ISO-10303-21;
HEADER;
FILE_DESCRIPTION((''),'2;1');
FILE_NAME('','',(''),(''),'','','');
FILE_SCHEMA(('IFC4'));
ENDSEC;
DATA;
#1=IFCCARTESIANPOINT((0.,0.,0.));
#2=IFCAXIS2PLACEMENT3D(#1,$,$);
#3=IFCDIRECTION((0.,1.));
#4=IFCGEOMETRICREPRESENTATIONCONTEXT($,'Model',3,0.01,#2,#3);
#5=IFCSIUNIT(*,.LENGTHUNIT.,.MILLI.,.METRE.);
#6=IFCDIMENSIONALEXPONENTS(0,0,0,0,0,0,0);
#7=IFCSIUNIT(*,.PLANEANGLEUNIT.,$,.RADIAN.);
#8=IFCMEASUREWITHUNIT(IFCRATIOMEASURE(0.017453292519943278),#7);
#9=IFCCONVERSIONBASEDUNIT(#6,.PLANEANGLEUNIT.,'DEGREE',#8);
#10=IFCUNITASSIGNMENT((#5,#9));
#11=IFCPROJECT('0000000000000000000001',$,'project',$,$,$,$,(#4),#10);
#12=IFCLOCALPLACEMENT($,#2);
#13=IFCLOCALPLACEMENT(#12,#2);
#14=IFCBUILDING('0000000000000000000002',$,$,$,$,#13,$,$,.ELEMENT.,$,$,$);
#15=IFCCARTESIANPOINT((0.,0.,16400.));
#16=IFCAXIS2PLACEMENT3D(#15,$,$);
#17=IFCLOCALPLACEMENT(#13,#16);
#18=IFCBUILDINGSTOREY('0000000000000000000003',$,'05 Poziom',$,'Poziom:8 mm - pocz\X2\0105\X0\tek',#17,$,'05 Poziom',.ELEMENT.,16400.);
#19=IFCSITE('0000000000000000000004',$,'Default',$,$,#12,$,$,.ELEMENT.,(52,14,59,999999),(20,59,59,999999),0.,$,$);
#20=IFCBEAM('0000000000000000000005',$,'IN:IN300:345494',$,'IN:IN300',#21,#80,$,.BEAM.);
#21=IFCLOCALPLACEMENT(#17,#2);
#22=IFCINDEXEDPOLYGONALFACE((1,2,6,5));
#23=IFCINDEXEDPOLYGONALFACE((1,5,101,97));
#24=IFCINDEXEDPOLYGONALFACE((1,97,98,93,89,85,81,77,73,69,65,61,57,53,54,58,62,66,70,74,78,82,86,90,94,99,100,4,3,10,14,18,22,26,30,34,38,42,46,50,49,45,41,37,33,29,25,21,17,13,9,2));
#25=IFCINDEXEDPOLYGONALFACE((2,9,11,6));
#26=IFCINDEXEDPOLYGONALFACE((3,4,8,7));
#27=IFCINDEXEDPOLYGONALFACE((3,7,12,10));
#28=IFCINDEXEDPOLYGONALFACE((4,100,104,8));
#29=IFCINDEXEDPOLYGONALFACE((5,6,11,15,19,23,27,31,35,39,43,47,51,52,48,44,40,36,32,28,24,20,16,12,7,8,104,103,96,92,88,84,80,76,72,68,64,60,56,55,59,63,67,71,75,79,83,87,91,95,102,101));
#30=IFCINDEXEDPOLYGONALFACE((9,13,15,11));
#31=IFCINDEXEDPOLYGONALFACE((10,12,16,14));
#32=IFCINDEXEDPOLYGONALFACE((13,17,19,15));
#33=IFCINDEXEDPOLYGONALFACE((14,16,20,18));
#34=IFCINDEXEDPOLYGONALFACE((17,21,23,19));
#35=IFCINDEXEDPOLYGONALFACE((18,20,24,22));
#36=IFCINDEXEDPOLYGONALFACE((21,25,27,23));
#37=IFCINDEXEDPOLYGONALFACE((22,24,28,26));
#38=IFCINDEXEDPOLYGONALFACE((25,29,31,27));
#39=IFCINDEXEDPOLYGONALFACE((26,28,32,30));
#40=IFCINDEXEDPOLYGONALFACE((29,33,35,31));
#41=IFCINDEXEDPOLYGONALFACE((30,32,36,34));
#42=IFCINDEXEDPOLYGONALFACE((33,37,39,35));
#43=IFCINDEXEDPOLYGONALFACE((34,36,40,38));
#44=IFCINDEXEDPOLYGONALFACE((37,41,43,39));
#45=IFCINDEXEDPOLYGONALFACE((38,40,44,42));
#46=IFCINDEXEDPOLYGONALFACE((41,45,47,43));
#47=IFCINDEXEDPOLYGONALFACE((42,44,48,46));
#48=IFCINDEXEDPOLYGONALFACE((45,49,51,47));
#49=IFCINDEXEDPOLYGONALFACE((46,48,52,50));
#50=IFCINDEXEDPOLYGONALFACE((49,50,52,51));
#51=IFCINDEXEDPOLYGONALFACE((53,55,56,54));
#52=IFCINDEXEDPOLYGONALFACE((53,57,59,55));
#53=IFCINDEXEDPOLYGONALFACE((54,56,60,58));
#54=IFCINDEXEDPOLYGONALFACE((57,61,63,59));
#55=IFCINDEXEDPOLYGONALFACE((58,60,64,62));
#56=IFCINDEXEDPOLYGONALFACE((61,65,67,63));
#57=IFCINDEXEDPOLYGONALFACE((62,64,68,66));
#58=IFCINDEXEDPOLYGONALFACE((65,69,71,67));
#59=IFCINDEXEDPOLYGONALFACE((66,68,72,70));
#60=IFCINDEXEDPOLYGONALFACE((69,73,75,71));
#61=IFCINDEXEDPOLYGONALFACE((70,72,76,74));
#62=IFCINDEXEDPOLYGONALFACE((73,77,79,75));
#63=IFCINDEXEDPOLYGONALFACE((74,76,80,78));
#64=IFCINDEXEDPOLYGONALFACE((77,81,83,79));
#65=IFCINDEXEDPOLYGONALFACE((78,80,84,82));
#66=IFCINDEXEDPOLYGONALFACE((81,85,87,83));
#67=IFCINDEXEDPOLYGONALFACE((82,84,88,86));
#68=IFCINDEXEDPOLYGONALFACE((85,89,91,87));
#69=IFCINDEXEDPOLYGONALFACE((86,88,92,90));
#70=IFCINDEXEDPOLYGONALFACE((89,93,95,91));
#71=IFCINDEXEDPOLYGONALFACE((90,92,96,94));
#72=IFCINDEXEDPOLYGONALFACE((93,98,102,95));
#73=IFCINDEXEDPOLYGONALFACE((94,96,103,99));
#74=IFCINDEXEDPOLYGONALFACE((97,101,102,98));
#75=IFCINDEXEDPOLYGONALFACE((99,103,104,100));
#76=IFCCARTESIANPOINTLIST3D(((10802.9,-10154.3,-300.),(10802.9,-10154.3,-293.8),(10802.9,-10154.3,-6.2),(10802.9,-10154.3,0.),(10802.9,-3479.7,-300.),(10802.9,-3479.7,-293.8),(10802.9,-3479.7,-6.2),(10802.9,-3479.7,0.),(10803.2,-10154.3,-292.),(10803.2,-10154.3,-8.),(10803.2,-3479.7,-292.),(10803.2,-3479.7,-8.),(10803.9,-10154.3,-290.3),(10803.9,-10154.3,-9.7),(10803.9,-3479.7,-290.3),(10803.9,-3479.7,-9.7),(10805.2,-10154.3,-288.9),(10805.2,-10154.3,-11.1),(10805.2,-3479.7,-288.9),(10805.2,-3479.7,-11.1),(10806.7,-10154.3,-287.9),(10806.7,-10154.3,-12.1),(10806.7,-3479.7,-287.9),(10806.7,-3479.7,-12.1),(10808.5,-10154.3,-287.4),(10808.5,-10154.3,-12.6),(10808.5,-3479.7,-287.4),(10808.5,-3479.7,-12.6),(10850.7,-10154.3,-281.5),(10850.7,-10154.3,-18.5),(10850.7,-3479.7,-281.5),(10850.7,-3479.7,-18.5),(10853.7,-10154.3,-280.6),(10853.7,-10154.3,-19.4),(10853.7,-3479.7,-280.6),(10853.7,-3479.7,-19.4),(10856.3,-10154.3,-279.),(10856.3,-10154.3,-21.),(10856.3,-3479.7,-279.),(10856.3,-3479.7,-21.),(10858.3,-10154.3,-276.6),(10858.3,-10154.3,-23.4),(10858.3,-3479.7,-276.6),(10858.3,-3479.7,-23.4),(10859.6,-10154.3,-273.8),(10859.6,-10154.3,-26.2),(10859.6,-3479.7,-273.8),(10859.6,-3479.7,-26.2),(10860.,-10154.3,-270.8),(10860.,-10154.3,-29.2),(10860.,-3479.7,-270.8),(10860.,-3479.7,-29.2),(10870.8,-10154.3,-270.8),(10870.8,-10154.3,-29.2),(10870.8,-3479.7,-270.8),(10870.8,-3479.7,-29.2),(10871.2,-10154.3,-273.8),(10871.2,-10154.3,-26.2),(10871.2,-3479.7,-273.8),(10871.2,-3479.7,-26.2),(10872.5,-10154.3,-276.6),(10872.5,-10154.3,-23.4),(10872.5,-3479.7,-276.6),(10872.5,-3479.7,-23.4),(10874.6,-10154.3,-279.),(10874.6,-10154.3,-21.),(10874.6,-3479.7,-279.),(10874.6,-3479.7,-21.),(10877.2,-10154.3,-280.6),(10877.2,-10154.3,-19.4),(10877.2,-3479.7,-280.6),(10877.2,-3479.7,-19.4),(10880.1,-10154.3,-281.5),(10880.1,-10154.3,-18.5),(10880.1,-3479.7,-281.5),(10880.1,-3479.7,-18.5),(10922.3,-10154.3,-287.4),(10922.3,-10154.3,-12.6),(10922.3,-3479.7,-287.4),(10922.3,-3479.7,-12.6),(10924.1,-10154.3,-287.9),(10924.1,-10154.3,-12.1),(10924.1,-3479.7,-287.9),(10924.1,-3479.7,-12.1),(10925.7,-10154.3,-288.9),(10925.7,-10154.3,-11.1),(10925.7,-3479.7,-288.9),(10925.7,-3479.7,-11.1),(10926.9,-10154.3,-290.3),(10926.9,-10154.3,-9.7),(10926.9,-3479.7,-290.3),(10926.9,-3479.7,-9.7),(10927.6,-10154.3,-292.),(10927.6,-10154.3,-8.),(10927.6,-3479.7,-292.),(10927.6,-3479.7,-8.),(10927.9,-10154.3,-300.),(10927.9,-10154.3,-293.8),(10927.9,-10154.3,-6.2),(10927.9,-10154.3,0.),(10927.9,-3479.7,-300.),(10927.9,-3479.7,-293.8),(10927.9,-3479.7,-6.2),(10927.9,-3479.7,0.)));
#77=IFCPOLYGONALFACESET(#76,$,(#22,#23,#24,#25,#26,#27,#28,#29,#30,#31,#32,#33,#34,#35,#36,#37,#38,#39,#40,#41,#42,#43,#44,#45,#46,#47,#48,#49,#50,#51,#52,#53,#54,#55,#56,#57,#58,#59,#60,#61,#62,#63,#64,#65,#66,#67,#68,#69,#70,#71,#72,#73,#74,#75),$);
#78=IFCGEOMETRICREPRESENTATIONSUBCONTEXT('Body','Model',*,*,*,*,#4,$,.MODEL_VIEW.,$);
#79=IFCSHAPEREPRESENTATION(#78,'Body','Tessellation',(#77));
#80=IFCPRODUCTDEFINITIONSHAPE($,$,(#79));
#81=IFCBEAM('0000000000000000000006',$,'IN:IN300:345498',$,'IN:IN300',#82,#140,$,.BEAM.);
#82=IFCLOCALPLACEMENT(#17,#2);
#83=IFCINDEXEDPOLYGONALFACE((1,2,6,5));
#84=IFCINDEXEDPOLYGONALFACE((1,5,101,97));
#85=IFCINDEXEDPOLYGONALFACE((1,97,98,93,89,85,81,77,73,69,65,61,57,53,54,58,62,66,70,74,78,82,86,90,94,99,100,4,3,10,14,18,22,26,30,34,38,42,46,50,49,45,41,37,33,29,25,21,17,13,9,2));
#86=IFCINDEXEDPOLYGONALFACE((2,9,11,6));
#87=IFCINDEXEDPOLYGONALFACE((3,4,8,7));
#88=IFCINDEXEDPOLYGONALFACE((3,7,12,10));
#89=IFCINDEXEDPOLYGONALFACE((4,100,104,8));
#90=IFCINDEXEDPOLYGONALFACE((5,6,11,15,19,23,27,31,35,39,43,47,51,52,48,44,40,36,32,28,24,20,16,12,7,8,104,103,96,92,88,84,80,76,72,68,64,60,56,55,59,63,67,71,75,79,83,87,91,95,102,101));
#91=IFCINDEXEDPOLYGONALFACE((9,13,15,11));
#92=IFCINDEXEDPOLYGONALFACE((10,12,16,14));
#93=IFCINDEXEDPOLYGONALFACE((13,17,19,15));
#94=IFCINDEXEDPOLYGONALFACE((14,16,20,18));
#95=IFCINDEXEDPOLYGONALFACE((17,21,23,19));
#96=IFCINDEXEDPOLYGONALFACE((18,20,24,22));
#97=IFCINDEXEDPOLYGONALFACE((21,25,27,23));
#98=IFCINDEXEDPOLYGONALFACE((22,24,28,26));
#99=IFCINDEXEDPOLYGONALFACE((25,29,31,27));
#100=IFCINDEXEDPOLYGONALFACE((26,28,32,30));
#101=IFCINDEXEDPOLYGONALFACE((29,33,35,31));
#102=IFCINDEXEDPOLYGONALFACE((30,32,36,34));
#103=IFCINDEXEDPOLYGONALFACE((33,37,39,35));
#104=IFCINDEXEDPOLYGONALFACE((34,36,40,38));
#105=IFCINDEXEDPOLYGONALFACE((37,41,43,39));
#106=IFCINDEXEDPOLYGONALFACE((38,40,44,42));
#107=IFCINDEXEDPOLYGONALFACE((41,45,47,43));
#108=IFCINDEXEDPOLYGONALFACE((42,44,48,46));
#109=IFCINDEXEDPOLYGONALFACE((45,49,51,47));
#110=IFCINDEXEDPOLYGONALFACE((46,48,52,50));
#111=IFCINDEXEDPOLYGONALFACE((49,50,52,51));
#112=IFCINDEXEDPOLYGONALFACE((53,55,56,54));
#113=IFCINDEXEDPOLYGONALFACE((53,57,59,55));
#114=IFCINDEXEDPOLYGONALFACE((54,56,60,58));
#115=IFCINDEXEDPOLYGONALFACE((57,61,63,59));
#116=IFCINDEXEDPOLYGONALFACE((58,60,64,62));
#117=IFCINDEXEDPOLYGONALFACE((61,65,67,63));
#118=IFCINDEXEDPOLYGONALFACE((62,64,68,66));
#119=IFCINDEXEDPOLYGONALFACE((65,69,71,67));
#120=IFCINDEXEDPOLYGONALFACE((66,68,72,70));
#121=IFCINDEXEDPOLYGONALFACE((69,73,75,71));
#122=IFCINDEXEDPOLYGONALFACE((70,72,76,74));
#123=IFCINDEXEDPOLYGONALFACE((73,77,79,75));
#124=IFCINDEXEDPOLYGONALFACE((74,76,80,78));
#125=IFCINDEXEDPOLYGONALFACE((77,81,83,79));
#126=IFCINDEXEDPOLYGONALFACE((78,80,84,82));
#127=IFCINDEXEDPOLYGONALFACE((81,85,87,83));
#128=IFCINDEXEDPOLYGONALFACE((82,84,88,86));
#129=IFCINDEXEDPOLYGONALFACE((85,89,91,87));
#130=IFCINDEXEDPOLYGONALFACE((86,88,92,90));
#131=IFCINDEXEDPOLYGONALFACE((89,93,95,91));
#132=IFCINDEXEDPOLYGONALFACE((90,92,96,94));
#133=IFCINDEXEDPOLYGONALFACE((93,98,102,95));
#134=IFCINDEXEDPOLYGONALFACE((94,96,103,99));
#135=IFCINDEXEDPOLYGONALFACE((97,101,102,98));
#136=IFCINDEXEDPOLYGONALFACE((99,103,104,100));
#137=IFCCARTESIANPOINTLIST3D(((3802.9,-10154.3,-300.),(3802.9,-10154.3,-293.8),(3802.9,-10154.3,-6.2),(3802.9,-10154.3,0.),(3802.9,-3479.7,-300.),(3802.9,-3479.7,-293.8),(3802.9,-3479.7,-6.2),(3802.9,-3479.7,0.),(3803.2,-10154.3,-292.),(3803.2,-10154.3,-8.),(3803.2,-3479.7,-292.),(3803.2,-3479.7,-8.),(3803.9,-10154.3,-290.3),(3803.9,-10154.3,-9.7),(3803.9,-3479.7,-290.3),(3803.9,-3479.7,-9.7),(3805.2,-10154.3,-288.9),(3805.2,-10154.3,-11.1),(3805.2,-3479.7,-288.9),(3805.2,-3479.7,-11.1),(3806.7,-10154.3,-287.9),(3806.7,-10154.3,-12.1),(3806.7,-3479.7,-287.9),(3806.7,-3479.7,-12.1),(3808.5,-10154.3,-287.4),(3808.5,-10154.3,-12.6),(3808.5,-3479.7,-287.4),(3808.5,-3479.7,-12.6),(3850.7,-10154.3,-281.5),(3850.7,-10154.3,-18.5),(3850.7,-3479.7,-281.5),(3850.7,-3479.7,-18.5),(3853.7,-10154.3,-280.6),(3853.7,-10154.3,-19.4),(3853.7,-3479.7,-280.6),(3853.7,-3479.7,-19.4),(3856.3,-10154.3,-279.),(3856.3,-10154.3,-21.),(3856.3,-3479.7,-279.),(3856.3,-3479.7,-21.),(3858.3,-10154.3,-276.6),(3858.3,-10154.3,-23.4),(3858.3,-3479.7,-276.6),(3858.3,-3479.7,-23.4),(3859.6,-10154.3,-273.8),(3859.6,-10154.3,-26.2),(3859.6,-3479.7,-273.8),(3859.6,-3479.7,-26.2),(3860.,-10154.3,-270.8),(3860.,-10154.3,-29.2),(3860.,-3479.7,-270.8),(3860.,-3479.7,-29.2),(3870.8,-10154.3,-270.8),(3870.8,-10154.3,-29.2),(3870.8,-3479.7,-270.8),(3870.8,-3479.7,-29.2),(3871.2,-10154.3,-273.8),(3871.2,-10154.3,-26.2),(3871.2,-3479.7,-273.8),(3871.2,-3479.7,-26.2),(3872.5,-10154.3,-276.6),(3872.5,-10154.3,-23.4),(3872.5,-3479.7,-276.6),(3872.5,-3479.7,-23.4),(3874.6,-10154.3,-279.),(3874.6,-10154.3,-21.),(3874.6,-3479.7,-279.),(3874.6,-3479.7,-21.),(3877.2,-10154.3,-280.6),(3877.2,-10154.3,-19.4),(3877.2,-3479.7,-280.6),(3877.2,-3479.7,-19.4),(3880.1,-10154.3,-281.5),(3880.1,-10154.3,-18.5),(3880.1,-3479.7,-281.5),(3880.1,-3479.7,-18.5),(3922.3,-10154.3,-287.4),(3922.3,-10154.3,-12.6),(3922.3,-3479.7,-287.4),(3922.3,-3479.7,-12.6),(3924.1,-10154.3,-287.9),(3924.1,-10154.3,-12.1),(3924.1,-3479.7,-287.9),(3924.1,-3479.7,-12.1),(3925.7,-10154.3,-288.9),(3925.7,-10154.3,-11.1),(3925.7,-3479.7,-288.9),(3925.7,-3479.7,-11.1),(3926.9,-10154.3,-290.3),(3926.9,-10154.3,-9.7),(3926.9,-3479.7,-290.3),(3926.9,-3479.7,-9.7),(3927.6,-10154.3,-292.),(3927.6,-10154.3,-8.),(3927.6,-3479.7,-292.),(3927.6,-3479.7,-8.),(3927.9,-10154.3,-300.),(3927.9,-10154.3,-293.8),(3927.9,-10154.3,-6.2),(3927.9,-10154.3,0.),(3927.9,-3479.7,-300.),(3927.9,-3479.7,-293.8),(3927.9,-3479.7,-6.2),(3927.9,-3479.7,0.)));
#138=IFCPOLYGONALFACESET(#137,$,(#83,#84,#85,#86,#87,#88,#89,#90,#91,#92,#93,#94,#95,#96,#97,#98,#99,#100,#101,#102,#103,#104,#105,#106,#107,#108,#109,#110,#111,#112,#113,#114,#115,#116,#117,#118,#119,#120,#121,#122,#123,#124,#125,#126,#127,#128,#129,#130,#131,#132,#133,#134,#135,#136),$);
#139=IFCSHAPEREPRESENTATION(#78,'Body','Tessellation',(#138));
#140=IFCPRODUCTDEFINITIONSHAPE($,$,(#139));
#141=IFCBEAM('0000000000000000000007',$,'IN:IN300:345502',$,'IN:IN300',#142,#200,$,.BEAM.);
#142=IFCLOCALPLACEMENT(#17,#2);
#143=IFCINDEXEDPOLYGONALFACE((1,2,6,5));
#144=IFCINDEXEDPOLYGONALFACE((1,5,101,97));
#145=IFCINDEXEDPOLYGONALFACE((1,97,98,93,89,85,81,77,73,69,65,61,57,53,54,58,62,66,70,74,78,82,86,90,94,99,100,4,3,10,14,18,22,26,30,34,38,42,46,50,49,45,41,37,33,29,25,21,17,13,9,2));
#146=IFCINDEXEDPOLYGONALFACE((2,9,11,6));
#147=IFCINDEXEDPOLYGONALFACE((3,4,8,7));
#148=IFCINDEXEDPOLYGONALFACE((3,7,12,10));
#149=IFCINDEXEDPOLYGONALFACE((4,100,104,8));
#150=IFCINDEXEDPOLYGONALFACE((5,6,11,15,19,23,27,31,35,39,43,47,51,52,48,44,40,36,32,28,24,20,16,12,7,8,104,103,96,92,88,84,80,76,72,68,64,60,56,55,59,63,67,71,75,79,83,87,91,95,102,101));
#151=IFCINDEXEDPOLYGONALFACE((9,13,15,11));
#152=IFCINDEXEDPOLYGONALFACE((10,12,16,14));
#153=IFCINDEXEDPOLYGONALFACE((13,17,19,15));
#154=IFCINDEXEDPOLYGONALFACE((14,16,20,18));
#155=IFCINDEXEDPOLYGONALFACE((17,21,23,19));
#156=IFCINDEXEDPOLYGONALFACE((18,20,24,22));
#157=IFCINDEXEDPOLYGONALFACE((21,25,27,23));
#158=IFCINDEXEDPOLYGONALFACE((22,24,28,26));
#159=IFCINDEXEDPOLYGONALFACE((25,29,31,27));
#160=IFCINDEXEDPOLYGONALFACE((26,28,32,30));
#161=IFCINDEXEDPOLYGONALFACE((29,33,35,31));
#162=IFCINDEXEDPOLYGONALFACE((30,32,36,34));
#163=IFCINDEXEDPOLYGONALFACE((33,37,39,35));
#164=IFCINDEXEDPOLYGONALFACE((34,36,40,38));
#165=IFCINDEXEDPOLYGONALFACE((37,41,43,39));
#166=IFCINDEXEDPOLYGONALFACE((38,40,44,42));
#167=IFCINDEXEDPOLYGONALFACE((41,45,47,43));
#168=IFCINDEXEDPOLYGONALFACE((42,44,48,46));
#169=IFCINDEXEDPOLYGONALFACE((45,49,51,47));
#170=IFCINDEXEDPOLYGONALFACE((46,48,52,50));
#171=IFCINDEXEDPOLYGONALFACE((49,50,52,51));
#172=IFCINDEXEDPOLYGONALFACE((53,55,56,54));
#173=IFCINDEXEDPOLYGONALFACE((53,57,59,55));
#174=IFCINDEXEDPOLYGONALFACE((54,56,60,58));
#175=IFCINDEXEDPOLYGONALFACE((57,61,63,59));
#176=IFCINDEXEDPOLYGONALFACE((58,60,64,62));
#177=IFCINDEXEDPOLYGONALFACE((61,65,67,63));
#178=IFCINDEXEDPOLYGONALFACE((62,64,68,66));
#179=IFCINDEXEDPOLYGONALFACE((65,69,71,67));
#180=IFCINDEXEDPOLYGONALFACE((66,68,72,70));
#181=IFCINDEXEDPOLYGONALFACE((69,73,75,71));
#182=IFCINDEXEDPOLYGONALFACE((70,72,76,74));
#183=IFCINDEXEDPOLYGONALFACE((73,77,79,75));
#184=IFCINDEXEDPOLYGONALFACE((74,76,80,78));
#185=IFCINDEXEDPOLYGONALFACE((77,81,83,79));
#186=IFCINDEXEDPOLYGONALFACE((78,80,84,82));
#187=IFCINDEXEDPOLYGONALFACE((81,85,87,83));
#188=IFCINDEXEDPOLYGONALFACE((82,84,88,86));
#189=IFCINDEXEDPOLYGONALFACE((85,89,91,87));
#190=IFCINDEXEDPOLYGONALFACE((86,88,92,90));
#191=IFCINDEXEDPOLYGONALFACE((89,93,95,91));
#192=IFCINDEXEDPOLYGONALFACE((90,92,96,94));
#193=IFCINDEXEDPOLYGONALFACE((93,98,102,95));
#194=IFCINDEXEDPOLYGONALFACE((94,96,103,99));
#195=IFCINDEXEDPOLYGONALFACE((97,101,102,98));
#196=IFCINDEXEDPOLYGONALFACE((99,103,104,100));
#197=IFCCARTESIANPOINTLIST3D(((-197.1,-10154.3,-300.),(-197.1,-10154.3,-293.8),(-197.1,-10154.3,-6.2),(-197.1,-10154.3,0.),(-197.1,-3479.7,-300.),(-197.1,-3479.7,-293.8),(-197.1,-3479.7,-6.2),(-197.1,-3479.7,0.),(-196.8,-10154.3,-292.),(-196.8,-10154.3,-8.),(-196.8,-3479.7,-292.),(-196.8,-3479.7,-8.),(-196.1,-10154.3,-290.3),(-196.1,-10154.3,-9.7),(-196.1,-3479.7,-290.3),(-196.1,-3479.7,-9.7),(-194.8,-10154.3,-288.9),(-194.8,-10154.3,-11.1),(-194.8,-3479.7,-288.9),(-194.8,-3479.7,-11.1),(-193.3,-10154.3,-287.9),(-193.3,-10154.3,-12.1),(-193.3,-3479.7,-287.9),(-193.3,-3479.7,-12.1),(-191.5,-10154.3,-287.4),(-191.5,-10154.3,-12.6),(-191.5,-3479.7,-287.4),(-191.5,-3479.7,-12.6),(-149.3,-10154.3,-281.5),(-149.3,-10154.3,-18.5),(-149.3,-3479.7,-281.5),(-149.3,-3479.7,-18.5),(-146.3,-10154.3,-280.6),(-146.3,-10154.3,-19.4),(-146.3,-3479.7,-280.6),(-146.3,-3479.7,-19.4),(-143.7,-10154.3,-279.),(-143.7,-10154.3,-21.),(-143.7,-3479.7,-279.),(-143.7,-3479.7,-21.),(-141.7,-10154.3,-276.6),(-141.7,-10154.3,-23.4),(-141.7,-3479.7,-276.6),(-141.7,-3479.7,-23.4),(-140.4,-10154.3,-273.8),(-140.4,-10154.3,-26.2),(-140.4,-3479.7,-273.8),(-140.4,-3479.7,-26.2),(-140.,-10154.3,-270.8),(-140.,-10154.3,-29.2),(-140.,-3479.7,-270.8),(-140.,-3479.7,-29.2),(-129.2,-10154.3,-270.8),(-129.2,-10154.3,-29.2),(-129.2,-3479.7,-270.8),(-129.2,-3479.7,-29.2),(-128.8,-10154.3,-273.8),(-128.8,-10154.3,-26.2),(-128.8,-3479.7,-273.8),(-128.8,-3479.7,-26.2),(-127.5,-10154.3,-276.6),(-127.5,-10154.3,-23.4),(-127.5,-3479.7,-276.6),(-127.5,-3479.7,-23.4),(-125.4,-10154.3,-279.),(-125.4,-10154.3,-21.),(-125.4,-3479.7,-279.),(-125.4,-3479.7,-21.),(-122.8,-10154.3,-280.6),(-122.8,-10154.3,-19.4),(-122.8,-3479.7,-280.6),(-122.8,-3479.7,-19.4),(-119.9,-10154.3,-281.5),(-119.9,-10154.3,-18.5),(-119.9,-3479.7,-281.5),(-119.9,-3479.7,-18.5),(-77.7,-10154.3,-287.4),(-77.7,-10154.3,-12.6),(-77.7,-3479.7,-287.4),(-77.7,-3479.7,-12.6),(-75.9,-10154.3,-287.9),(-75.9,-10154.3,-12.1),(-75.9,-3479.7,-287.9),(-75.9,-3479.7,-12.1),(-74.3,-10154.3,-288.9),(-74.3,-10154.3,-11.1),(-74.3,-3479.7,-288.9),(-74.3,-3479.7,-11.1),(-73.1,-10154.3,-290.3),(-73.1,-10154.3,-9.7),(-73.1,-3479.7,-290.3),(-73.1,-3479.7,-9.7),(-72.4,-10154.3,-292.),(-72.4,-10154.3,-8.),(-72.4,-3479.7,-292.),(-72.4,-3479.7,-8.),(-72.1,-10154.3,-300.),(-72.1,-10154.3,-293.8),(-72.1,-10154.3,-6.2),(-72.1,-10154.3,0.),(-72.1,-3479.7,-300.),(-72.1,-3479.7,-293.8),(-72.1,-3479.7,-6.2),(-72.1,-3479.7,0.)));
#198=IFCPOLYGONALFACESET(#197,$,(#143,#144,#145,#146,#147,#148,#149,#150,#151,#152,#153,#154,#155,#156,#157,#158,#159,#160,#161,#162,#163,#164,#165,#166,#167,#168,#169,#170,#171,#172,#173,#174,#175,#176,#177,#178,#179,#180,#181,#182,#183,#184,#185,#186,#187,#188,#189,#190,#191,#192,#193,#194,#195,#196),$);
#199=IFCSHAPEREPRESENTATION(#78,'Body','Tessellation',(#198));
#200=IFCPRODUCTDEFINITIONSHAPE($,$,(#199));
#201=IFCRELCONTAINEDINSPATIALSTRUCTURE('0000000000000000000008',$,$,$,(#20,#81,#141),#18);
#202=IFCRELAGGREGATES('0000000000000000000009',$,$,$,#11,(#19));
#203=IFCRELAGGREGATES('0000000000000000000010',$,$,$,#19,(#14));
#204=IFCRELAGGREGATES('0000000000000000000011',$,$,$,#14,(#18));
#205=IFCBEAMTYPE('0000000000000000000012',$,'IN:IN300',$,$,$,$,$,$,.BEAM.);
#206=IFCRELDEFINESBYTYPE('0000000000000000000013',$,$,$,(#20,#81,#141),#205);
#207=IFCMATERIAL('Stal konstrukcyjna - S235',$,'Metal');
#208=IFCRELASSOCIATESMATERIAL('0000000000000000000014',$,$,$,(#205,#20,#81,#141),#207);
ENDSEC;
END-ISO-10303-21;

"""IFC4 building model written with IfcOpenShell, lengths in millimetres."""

from ifc_helpers import new_model, entity, si_unit, converted_unit, direction, frame, origin, place, context, subcontext, project, spatial, line, arc, indexed_curve, outline, extrude, source, transform, mapped, material, type_object, type_shapes, element, save


model = new_model("IFC4")

# Units and contexts
model_context = context("Model", 3, precision=0.01, world=origin(), true_north=direction((0.0, 1.0)))
body_context = subcontext(model_context, "Body", "Model", "MODEL_VIEW")
ifc_project = project(units=[si_unit("LENGTHUNIT", "METRE", prefix="MILLI"), converted_unit("PLANEANGLEUNIT", "DEGREE", entity("IfcRatioMeasure", 0.017453292519943278), si_unit("PLANEANGLEUNIT", "RADIAN"), dimensions=[0, 0, 0, 0, 0, 0, 0])], contexts=[model_context])

# Site, building, storey
site_placement = place(None, origin())
site = spatial("IfcSite", under=ifc_project, at=site_placement, Name="Default", CompositionType="ELEMENT", RefLatitude=(52, 14, 59, 999999), RefLongitude=(20, 59, 59, 999999), RefElevation=0.0)
building_placement = place(site_placement, origin())
building = spatial("IfcBuilding", under=site, at=building_placement, CompositionType="ELEMENT")
storey_placement = place(building_placement, frame((0.0, 0.0, 16400.0)))
storey = spatial("IfcBuildingStorey", under=building, at=storey_placement, Name="05 Poziom", ObjectType="Poziom:8 mm - początek", LongName="05 Poziom", CompositionType="ELEMENT", Elevation=16400.0)

# Shared definitions
ifc_material = material(Name="Stal konstrukcyjna - S235", Category="Metal")

# Beams
beam_type_1 = type_object("IfcBeamType", Name="IN:IN300", PredefinedType="BEAM", material=ifc_material)
shared_shape_1 = source(origin(), body_context, "Body", "SweptSolid", [
    extrude(outline(indexed_curve([(143.8, -62.5), (150.0, -62.5), (150.0, 62.5), (143.8, 62.5), (139.6, 60.9), (137.4, 56.9), (131.5, 14.7), (127.9, 8.1), (120.8, 5.4), (-120.8, 5.4), (-127.9, 8.1), (-131.5, 14.7), (-137.4, 56.9), (-139.6, 60.9), (-143.8, 62.5), (-150.0, 62.5), (-150.0, -62.5), (-143.8, -62.5), (-139.6, -60.9), (-137.4, -56.9), (-131.5, -14.7), (-127.9, -8.1), (-120.8, -5.4), (120.8, -5.4), (127.9, -8.1), (131.5, -14.7), (137.4, -56.9), (139.6, -60.9)], segments=[line(1, 2, 3, 4), arc(4, 5, 6), line(6, 7), arc(7, 8, 9), line(9, 10), arc(10, 11, 12), line(12, 13), arc(13, 14, 15), line(15, 16, 17, 18), arc(18, 19, 20), line(20, 21), arc(21, 22, 23), line(23, 24), arc(24, 25, 26), line(26, 27), arc(27, 28, 1)], self_intersect=False)), frame((-3337.3, 0.0, 0.0), z_axis=(1.0, 0.0, 0.0), x_axis=(0.0, 0.0, -1.0)), (0.0, 0.0, 1.0), 6674.6),
])
type_shapes(beam_type_1, [shared_shape_1])
for number, where, z_axis, x_axis, name in (
    (1, (10865.4, -6817.0, -150.0), (0.0, 0.0, 1.0), (0.0, -1.0, 0.0), "IN:IN300:345494"),
    (2, (3865.4, -6817.0, -150.0), (0.0, 0.0, 1.0), (0.0, -1.0, 0.0), "IN:IN300:345498"),
    (3, (-134.6, -6817.0, -150.0), (0.0, 0.0, 1.0), (0.0, -1.0, 0.0), "IN:IN300:345502"),
):
    element("IfcBeam", number, at=place(storey_placement, frame(where, z_axis=z_axis, x_axis=x_axis)), inside=storey, type_object=beam_type_1, material=ifc_material, Name=name, ObjectType="IN:IN300", PredefinedType="BEAM", context=body_context, shape_type="MappedRepresentation", body=[
        mapped(shared_shape_1, transform((0.0, 0.0, 0.0), scale=1.0)),
    ])

save(model, "model.ifc")
